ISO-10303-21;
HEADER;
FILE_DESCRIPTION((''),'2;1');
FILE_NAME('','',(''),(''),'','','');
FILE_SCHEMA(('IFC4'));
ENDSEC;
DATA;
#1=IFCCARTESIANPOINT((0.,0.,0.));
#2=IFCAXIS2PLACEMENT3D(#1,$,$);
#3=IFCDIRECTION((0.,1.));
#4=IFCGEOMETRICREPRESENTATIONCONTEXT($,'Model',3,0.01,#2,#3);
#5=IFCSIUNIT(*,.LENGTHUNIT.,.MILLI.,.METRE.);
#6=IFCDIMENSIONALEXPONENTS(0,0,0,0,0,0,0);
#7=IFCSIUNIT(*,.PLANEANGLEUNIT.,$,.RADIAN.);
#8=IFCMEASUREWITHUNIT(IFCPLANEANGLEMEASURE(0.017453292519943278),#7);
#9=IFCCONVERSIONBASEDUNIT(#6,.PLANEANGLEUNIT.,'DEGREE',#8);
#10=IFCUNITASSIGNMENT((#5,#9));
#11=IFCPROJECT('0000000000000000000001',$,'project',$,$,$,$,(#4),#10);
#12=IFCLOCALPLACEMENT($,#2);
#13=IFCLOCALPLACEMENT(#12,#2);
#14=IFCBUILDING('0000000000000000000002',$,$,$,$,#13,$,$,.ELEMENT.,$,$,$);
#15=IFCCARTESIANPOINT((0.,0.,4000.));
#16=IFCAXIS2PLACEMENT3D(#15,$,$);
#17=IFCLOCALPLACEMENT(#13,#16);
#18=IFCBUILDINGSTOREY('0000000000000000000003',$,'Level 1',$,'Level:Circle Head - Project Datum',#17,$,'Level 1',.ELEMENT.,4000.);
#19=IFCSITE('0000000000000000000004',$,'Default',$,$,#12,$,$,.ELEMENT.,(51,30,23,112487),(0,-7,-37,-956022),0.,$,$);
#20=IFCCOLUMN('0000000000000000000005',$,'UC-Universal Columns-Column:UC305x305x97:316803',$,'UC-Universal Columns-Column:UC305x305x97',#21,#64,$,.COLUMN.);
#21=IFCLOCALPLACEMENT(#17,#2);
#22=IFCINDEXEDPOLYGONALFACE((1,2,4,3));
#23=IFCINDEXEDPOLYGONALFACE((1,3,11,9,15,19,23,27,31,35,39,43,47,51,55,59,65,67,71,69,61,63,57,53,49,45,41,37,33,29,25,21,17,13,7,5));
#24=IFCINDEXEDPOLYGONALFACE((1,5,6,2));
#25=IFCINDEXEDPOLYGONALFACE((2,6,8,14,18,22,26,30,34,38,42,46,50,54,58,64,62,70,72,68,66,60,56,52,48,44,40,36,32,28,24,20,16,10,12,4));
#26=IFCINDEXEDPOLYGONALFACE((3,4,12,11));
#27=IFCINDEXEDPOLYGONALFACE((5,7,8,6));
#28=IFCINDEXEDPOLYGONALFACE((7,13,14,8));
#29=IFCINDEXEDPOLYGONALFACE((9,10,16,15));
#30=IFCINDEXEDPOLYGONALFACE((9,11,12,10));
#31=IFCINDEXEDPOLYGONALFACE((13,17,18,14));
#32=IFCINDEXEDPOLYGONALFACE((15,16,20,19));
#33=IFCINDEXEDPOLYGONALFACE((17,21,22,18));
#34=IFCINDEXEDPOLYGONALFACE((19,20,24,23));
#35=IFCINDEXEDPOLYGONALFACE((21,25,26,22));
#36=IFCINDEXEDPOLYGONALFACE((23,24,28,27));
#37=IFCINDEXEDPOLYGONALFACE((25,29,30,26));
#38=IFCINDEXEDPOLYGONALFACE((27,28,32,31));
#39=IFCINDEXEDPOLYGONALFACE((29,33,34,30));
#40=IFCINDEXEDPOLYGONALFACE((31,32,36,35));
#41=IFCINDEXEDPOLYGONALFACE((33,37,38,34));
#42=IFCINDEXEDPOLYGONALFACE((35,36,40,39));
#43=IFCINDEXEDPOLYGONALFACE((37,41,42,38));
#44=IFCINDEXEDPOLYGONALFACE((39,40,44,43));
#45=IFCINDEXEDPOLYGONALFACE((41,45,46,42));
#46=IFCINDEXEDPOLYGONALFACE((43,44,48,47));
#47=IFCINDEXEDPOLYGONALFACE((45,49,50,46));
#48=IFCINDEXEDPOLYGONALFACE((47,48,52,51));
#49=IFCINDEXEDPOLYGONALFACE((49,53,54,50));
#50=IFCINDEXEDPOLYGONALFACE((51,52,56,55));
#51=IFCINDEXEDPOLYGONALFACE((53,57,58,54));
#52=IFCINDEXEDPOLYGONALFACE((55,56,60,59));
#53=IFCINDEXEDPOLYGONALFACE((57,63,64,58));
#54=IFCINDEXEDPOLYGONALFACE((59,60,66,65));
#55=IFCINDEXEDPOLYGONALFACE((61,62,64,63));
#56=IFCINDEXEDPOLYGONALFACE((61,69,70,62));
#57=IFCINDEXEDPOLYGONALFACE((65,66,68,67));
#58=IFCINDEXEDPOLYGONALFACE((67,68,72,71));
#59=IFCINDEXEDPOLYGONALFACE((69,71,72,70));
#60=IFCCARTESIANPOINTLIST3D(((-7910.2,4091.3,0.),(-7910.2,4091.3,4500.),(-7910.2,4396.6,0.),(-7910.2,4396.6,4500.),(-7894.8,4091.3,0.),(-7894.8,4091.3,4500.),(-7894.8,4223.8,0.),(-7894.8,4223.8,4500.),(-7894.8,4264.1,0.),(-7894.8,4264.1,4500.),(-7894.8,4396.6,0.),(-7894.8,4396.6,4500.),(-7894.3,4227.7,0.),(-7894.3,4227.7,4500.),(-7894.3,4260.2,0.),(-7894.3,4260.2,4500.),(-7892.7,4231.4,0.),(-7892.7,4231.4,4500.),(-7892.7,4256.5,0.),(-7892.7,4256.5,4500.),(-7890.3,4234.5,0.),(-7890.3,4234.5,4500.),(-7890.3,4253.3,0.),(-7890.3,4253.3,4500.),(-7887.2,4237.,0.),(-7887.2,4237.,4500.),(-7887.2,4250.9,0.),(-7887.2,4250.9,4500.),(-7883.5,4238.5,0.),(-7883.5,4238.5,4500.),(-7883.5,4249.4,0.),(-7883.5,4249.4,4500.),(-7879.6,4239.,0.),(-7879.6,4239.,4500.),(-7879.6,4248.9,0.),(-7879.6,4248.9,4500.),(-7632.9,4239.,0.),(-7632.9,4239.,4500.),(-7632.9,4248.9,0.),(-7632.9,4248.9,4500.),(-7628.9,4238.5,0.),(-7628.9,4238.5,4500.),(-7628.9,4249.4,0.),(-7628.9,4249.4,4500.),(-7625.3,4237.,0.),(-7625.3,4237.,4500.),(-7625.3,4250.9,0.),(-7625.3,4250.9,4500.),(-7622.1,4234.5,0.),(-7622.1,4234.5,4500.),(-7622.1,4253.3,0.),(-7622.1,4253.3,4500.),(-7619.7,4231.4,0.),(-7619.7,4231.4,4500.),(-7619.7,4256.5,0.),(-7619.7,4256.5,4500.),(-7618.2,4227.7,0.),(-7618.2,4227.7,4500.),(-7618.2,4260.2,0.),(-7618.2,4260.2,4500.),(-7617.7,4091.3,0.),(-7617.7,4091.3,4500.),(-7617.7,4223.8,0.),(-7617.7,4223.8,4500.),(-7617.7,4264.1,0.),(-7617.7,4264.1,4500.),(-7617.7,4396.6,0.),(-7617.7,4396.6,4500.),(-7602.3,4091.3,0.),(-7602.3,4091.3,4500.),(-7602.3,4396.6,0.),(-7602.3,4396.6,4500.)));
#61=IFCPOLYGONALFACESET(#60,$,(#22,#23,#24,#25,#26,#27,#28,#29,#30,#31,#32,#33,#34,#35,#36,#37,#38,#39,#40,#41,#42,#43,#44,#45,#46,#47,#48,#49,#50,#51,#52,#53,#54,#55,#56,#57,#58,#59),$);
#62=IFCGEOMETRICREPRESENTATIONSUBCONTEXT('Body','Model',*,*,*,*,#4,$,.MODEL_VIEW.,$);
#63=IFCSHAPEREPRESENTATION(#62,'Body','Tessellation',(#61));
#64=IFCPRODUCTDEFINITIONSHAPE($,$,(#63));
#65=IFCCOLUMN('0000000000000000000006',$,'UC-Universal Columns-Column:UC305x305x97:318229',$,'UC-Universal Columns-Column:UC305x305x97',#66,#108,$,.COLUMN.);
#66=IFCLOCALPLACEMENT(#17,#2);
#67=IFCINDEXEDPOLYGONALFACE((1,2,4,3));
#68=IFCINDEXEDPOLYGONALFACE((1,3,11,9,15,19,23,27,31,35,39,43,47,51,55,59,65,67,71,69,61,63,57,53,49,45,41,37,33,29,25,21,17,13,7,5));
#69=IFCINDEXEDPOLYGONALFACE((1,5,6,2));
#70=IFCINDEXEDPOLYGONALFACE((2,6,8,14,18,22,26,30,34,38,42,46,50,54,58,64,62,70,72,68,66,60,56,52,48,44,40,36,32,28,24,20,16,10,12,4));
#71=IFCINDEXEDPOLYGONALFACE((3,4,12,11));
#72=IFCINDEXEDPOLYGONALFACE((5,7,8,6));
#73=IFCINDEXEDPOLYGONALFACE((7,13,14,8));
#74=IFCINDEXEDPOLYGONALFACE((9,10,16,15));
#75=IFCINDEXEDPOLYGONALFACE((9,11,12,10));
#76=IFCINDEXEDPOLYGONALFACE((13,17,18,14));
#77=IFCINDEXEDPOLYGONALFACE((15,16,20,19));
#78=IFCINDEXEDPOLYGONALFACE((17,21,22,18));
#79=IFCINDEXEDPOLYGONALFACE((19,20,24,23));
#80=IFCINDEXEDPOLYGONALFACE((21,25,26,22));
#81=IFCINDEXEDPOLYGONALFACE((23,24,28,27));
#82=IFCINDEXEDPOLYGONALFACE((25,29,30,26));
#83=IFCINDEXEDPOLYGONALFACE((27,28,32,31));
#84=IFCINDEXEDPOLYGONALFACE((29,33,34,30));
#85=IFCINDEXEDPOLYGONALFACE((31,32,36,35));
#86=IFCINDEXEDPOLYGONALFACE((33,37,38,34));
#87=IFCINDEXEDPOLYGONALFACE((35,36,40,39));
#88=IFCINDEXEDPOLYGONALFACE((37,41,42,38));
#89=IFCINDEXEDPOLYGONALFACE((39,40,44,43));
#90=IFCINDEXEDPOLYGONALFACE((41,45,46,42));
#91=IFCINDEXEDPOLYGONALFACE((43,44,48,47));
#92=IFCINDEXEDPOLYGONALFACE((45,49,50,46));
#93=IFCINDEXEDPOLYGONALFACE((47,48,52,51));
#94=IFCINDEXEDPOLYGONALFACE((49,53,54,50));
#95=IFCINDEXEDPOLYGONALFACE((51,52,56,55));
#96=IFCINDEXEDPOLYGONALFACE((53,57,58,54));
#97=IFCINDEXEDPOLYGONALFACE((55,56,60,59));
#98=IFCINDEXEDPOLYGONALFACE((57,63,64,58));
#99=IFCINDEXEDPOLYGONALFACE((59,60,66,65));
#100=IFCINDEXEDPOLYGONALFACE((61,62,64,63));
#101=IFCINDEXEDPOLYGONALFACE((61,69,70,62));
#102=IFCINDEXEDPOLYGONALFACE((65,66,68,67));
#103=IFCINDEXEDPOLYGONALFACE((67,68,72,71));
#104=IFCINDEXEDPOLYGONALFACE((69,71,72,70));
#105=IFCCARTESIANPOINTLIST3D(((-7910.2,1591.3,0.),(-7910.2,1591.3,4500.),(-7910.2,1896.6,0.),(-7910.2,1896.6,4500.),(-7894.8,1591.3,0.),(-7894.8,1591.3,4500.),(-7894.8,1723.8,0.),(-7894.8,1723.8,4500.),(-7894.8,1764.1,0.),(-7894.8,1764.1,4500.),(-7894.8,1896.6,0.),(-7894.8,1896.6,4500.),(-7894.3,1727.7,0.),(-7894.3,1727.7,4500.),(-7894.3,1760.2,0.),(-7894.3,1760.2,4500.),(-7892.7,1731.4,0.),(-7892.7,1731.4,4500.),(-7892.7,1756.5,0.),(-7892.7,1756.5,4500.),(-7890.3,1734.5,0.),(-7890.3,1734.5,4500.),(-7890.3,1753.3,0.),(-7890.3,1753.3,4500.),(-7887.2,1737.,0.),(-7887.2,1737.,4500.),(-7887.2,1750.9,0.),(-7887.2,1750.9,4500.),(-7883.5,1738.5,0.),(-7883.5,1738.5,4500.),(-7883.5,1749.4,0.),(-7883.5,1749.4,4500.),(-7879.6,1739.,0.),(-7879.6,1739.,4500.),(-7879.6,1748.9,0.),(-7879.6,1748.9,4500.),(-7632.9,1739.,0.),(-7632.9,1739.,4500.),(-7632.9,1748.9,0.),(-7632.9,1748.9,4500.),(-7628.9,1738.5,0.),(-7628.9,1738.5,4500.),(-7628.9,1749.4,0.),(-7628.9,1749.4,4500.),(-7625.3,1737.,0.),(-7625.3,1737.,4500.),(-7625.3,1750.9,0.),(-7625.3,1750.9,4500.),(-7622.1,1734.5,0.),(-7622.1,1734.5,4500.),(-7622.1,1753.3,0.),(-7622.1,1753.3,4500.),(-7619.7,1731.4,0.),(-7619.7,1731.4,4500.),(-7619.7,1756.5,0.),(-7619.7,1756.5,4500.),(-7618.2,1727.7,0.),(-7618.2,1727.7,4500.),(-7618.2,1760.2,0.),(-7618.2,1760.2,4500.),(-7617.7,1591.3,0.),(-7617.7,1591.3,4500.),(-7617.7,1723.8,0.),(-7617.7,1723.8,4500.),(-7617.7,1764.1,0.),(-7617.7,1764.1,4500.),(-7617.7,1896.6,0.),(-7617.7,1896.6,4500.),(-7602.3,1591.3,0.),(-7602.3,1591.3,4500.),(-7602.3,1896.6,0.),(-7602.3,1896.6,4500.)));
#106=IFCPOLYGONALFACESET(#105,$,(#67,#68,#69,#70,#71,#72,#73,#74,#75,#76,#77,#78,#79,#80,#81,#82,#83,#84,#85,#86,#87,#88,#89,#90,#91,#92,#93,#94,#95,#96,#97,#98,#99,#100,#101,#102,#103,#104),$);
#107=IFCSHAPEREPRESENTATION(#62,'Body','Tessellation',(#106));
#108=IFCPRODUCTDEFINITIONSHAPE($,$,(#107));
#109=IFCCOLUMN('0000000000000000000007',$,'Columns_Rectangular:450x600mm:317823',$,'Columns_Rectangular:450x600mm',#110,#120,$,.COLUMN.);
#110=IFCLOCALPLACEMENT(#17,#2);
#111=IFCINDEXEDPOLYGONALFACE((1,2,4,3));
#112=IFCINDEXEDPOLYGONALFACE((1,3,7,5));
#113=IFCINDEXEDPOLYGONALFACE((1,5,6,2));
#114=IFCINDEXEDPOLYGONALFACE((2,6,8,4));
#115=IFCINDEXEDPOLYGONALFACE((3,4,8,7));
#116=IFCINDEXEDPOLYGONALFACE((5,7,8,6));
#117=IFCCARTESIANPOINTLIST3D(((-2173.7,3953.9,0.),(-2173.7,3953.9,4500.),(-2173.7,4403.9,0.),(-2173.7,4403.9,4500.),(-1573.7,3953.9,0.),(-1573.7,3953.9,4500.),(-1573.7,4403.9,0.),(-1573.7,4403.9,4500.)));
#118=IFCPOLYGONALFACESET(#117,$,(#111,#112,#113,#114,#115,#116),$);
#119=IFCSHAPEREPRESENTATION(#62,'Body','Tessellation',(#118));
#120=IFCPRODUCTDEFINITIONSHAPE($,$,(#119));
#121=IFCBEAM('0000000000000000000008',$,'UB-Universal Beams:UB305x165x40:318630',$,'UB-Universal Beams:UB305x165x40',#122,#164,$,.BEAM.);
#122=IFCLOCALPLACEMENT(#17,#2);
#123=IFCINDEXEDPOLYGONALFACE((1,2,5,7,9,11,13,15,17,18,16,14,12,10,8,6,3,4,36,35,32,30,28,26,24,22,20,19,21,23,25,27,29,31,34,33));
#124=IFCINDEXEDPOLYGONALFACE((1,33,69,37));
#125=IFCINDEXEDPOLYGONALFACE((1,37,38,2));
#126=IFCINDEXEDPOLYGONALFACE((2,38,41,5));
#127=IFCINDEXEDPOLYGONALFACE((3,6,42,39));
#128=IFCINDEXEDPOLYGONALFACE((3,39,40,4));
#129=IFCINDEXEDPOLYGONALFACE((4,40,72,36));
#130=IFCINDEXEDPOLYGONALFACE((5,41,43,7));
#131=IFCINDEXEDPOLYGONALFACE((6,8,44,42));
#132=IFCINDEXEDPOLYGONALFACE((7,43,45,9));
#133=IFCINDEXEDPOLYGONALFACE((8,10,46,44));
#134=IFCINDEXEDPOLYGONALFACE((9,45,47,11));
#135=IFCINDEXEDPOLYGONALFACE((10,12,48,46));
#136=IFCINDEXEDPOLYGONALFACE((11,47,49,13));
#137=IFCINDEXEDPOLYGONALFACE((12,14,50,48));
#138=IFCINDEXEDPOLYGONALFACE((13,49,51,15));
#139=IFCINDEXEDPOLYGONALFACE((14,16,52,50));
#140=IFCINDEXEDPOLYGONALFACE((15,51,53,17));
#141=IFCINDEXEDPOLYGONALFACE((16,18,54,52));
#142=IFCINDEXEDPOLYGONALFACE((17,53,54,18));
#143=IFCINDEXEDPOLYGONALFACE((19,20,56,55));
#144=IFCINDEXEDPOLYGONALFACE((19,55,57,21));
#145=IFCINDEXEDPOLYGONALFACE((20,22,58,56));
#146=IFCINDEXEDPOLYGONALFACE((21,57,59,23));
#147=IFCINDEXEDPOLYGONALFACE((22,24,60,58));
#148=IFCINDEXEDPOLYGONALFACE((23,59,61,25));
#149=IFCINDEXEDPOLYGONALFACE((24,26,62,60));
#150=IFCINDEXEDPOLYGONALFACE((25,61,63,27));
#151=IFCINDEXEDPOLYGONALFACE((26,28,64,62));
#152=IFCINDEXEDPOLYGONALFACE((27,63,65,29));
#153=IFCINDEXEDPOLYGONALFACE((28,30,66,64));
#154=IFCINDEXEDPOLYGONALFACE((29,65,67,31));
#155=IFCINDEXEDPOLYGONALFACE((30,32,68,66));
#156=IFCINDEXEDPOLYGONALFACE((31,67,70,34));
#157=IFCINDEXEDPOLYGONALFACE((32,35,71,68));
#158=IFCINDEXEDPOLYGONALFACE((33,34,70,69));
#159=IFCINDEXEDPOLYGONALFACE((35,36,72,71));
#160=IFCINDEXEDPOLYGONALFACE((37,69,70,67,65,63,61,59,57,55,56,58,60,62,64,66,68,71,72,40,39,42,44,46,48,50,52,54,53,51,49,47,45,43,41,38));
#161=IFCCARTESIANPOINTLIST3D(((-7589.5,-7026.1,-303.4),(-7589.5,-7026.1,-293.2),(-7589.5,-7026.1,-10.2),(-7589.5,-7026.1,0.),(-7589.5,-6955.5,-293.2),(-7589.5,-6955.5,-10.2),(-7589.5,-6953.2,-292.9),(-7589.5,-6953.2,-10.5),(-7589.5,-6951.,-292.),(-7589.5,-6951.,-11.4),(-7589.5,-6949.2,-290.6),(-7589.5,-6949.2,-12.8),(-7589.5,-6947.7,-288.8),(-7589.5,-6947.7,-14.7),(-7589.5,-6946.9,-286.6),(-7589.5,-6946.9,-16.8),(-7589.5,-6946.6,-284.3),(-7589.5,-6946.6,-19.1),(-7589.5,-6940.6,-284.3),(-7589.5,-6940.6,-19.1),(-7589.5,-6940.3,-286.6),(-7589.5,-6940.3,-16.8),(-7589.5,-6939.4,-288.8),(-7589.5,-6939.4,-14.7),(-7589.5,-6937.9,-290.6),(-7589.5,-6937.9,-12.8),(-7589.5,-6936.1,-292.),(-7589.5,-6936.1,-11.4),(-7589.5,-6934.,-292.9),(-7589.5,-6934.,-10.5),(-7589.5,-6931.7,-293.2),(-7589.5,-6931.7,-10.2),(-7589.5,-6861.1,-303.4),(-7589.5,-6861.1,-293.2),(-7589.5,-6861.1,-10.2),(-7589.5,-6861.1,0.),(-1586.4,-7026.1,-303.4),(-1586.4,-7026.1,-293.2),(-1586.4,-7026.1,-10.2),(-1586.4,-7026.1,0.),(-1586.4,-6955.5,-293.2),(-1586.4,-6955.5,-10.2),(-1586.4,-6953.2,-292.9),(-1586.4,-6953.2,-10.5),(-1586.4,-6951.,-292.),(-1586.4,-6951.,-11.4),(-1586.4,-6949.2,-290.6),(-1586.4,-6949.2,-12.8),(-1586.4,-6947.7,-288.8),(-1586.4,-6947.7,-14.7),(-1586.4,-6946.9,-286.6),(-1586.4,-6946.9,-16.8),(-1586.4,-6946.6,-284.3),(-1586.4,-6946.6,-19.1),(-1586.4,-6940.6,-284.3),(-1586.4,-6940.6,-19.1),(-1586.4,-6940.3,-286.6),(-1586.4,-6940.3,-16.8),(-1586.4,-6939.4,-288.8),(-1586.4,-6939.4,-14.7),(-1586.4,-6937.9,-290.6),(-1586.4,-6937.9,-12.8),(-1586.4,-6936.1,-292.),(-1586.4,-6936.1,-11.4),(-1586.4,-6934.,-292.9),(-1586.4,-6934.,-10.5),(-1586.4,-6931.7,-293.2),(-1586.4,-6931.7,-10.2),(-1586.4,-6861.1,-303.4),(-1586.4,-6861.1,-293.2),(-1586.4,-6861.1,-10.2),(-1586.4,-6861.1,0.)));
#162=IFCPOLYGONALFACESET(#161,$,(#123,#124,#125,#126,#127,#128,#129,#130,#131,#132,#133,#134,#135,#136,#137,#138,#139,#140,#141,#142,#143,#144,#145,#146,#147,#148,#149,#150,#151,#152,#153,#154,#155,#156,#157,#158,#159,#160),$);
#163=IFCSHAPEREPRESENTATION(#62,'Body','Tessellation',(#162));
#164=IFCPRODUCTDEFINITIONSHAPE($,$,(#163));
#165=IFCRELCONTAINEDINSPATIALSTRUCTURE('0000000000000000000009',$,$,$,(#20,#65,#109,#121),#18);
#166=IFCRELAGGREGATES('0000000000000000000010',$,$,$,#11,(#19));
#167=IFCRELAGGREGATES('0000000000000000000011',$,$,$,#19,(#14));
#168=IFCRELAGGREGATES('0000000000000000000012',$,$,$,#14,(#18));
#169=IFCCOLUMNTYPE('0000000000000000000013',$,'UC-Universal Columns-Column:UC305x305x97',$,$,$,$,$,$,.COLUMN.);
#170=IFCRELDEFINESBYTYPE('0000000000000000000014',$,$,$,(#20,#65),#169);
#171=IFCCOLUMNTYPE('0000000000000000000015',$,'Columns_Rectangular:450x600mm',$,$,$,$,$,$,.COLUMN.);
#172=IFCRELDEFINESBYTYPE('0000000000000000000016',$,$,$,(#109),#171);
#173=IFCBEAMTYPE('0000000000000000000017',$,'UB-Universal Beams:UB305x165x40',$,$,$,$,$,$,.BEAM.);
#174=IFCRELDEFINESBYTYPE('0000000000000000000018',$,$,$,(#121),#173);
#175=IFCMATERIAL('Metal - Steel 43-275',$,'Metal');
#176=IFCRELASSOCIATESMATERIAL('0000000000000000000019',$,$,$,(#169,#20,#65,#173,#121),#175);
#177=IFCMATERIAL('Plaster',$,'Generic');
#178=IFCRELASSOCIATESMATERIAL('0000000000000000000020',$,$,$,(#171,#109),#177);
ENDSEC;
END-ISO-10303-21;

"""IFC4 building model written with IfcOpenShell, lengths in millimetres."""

from ifc_helpers import new_model, entity, si_unit, converted_unit, direction, frame, origin, place, context, subcontext, project, spatial, line, arc, indexed_curve, outline, extrude, source, transform, mapped, material, type_object, type_shapes, element, save


model = new_model("IFC4")

# Units and contexts
model_context = context("Model", 3, precision=0.01, world=origin(), true_north=direction((0.0, 1.0)))
body_context = subcontext(model_context, "Body", "Model", "MODEL_VIEW")
ifc_project = project(units=[si_unit("LENGTHUNIT", "METRE", prefix="MILLI"), converted_unit("PLANEANGLEUNIT", "DEGREE", entity("IfcPlaneAngleMeasure", 0.017453292519943278), si_unit("PLANEANGLEUNIT", "RADIAN"), dimensions=[0, 0, 0, 0, 0, 0, 0])], contexts=[model_context])

# Site, building, storey
site_placement = place(None, origin())
site = spatial("IfcSite", under=ifc_project, at=site_placement, Name="Default", CompositionType="ELEMENT", RefLatitude=(51, 30, 23, 112487), RefLongitude=(0, -7, -37, -956022), RefElevation=0.0)
building_placement = place(site_placement, origin())
building = spatial("IfcBuilding", under=site, at=building_placement, CompositionType="ELEMENT")
storey_placement = place(building_placement, frame((0.0, 0.0, 4000.0)))
storey = spatial("IfcBuildingStorey", under=building, at=storey_placement, Name="Level 1", ObjectType="Level:Circle Head - Project Datum", LongName="Level 1", CompositionType="ELEMENT", Elevation=4000.0)

# Columns
ifc_material_1 = material(Name="Metal - Steel 43-275", Category="Metal")
column_type_1 = type_object("IfcColumnType", Name="UC-Universal Columns-Column:UC305x305x97", PredefinedType="COLUMN", material=ifc_material_1)
shared_shape_1 = source(origin(), body_context, "Body", "SweptSolid", [
    extrude(outline(indexed_curve([(-152.6, -153.9), (152.6, -153.9), (152.6, -138.5), (20.2, -138.5), (9.4, -134.1), (4.9, -123.4), (4.9, 123.3), (9.4, 134.1), (20.1, 138.5), (152.6, 138.5), (152.6, 153.9), (-152.6, 153.9), (-152.6, 138.5), (-20.2, 138.6), (-9.4, 134.1), (-5.0, 123.4), (-5.0, -123.3), (-9.4, -134.1), (-20.2, -138.5), (-152.6, -138.5)], segments=[line(1, 2, 3, 4), arc(4, 5, 6), line(6, 7), arc(7, 8, 9), line(9, 10, 11, 12, 13, 14), arc(14, 15, 16), line(16, 17), arc(17, 18, 19), line(19, 20, 1)], self_intersect=False)), frame((0.0, 0.0, 4000.0), z_axis=(0.0, 0.0, 1.0), x_axis=(-1.0, 0.0, 0.0)), (0.0, 0.0, 1.0), 4500.0),
])
type_shapes(column_type_1, [shared_shape_1])
for number, where, z_axis, x_axis, name in (
    (1, (-7756.2, 4243.9, -4000.0), (0.0, 0.0, 1.0), (0.0, 1.0, 0.0), "UC-Universal Columns-Column:UC305x305x97:316803"),
    (2, (-7756.2, 1743.9, -4000.0), (0.0, 0.0, 1.0), (0.0, 1.0, 0.0), "UC-Universal Columns-Column:UC305x305x97:318229"),
):
    element("IfcColumn", number, at=place(storey_placement, frame(where, z_axis=z_axis, x_axis=x_axis)), inside=storey, type_object=column_type_1, material=ifc_material_1, Name=name, ObjectType="UC-Universal Columns-Column:UC305x305x97", PredefinedType="COLUMN", context=body_context, shape_type="MappedRepresentation", body=[
        mapped(shared_shape_1, transform((0.0, 0.0, 0.0), scale=1.0)),
    ])
ifc_material_2 = material(Name="Plaster", Category="Generic")
column_type_2 = type_object("IfcColumnType", Name="Columns_Rectangular:450x600mm", PredefinedType="COLUMN", material=ifc_material_2)
shared_shape_2 = source(origin(), body_context, "Body", "SweptSolid", [
    extrude(outline(indexed_curve([(-300.0, -225.0), (300.0, -225.0), (300.0, 225.0), (-300.0, 225.0), (-300.0, -225.0)], self_intersect=False)), frame((-1873.7, 4178.9, 4000.0), z_axis=(0.0, 0.0, 1.0), x_axis=(-1.0, 0.0, 0.0)), (0.0, 0.0, 1.0), 4500.0),
])
type_shapes(column_type_2, [shared_shape_2])
column_placement = place(storey_placement, frame((0.0, 0.0, -4000.0)))
element("IfcColumn", 3, at=column_placement, inside=storey, type_object=column_type_2, material=ifc_material_2, Name="Columns_Rectangular:450x600mm:317823", ObjectType="Columns_Rectangular:450x600mm", PredefinedType="COLUMN", context=body_context, shape_type="MappedRepresentation", body=[
    mapped(shared_shape_2, transform((0.0, 0.0, 0.0), scale=1.0)),
])

# Beam
beam_type_1 = type_object("IfcBeamType", Name="UB-Universal Beams:UB305x165x40", PredefinedType="BEAM", material=ifc_material_1)
shared_shape_3 = source(origin(), body_context, "Body", "SweptSolid", [
    extrude(outline(indexed_curve([(-82.5, -141.5), (-82.5, -151.7), (82.5, -151.7), (82.5, -141.5), (11.9, -141.5), (5.6, -138.9), (3.0, -132.6), (3.0, 132.6), (5.6, 138.9), (11.9, 141.5), (82.5, 141.5), (82.5, 151.7), (-82.5, 151.7), (-82.5, 141.5), (-11.9, 141.5), (-5.6, 138.9), (-3.0, 132.6), (-3.0, -132.6), (-5.6, -138.9), (-11.9, -141.5)], segments=[line(1, 2, 3, 4, 5), arc(5, 6, 7), line(7, 8), arc(8, 9, 10), line(10, 11, 12, 13, 14, 15), arc(15, 16, 17), line(17, 18), arc(18, 19, 20), line(20, 1)], self_intersect=False)), frame((-2863.3, 0.0, 0.0), z_axis=(-1.0, 0.0, 0.0), x_axis=(0.0, -1.0, 0.0)), (0.0, 0.0, -1.0), 6003.1),
])
type_shapes(beam_type_1, [shared_shape_3])
beam_1_placement = place(storey_placement, frame((-4726.2, -6943.6, -151.7)))
element("IfcBeam", 4, at=beam_1_placement, inside=storey, type_object=beam_type_1, material=ifc_material_1, Name="UB-Universal Beams:UB305x165x40:318630", ObjectType="UB-Universal Beams:UB305x165x40", PredefinedType="BEAM", context=body_context, shape_type="MappedRepresentation", body=[
    mapped(shared_shape_3, transform((0.0, 0.0, 0.0), scale=1.0)),
])

save(model, "model.ifc")
